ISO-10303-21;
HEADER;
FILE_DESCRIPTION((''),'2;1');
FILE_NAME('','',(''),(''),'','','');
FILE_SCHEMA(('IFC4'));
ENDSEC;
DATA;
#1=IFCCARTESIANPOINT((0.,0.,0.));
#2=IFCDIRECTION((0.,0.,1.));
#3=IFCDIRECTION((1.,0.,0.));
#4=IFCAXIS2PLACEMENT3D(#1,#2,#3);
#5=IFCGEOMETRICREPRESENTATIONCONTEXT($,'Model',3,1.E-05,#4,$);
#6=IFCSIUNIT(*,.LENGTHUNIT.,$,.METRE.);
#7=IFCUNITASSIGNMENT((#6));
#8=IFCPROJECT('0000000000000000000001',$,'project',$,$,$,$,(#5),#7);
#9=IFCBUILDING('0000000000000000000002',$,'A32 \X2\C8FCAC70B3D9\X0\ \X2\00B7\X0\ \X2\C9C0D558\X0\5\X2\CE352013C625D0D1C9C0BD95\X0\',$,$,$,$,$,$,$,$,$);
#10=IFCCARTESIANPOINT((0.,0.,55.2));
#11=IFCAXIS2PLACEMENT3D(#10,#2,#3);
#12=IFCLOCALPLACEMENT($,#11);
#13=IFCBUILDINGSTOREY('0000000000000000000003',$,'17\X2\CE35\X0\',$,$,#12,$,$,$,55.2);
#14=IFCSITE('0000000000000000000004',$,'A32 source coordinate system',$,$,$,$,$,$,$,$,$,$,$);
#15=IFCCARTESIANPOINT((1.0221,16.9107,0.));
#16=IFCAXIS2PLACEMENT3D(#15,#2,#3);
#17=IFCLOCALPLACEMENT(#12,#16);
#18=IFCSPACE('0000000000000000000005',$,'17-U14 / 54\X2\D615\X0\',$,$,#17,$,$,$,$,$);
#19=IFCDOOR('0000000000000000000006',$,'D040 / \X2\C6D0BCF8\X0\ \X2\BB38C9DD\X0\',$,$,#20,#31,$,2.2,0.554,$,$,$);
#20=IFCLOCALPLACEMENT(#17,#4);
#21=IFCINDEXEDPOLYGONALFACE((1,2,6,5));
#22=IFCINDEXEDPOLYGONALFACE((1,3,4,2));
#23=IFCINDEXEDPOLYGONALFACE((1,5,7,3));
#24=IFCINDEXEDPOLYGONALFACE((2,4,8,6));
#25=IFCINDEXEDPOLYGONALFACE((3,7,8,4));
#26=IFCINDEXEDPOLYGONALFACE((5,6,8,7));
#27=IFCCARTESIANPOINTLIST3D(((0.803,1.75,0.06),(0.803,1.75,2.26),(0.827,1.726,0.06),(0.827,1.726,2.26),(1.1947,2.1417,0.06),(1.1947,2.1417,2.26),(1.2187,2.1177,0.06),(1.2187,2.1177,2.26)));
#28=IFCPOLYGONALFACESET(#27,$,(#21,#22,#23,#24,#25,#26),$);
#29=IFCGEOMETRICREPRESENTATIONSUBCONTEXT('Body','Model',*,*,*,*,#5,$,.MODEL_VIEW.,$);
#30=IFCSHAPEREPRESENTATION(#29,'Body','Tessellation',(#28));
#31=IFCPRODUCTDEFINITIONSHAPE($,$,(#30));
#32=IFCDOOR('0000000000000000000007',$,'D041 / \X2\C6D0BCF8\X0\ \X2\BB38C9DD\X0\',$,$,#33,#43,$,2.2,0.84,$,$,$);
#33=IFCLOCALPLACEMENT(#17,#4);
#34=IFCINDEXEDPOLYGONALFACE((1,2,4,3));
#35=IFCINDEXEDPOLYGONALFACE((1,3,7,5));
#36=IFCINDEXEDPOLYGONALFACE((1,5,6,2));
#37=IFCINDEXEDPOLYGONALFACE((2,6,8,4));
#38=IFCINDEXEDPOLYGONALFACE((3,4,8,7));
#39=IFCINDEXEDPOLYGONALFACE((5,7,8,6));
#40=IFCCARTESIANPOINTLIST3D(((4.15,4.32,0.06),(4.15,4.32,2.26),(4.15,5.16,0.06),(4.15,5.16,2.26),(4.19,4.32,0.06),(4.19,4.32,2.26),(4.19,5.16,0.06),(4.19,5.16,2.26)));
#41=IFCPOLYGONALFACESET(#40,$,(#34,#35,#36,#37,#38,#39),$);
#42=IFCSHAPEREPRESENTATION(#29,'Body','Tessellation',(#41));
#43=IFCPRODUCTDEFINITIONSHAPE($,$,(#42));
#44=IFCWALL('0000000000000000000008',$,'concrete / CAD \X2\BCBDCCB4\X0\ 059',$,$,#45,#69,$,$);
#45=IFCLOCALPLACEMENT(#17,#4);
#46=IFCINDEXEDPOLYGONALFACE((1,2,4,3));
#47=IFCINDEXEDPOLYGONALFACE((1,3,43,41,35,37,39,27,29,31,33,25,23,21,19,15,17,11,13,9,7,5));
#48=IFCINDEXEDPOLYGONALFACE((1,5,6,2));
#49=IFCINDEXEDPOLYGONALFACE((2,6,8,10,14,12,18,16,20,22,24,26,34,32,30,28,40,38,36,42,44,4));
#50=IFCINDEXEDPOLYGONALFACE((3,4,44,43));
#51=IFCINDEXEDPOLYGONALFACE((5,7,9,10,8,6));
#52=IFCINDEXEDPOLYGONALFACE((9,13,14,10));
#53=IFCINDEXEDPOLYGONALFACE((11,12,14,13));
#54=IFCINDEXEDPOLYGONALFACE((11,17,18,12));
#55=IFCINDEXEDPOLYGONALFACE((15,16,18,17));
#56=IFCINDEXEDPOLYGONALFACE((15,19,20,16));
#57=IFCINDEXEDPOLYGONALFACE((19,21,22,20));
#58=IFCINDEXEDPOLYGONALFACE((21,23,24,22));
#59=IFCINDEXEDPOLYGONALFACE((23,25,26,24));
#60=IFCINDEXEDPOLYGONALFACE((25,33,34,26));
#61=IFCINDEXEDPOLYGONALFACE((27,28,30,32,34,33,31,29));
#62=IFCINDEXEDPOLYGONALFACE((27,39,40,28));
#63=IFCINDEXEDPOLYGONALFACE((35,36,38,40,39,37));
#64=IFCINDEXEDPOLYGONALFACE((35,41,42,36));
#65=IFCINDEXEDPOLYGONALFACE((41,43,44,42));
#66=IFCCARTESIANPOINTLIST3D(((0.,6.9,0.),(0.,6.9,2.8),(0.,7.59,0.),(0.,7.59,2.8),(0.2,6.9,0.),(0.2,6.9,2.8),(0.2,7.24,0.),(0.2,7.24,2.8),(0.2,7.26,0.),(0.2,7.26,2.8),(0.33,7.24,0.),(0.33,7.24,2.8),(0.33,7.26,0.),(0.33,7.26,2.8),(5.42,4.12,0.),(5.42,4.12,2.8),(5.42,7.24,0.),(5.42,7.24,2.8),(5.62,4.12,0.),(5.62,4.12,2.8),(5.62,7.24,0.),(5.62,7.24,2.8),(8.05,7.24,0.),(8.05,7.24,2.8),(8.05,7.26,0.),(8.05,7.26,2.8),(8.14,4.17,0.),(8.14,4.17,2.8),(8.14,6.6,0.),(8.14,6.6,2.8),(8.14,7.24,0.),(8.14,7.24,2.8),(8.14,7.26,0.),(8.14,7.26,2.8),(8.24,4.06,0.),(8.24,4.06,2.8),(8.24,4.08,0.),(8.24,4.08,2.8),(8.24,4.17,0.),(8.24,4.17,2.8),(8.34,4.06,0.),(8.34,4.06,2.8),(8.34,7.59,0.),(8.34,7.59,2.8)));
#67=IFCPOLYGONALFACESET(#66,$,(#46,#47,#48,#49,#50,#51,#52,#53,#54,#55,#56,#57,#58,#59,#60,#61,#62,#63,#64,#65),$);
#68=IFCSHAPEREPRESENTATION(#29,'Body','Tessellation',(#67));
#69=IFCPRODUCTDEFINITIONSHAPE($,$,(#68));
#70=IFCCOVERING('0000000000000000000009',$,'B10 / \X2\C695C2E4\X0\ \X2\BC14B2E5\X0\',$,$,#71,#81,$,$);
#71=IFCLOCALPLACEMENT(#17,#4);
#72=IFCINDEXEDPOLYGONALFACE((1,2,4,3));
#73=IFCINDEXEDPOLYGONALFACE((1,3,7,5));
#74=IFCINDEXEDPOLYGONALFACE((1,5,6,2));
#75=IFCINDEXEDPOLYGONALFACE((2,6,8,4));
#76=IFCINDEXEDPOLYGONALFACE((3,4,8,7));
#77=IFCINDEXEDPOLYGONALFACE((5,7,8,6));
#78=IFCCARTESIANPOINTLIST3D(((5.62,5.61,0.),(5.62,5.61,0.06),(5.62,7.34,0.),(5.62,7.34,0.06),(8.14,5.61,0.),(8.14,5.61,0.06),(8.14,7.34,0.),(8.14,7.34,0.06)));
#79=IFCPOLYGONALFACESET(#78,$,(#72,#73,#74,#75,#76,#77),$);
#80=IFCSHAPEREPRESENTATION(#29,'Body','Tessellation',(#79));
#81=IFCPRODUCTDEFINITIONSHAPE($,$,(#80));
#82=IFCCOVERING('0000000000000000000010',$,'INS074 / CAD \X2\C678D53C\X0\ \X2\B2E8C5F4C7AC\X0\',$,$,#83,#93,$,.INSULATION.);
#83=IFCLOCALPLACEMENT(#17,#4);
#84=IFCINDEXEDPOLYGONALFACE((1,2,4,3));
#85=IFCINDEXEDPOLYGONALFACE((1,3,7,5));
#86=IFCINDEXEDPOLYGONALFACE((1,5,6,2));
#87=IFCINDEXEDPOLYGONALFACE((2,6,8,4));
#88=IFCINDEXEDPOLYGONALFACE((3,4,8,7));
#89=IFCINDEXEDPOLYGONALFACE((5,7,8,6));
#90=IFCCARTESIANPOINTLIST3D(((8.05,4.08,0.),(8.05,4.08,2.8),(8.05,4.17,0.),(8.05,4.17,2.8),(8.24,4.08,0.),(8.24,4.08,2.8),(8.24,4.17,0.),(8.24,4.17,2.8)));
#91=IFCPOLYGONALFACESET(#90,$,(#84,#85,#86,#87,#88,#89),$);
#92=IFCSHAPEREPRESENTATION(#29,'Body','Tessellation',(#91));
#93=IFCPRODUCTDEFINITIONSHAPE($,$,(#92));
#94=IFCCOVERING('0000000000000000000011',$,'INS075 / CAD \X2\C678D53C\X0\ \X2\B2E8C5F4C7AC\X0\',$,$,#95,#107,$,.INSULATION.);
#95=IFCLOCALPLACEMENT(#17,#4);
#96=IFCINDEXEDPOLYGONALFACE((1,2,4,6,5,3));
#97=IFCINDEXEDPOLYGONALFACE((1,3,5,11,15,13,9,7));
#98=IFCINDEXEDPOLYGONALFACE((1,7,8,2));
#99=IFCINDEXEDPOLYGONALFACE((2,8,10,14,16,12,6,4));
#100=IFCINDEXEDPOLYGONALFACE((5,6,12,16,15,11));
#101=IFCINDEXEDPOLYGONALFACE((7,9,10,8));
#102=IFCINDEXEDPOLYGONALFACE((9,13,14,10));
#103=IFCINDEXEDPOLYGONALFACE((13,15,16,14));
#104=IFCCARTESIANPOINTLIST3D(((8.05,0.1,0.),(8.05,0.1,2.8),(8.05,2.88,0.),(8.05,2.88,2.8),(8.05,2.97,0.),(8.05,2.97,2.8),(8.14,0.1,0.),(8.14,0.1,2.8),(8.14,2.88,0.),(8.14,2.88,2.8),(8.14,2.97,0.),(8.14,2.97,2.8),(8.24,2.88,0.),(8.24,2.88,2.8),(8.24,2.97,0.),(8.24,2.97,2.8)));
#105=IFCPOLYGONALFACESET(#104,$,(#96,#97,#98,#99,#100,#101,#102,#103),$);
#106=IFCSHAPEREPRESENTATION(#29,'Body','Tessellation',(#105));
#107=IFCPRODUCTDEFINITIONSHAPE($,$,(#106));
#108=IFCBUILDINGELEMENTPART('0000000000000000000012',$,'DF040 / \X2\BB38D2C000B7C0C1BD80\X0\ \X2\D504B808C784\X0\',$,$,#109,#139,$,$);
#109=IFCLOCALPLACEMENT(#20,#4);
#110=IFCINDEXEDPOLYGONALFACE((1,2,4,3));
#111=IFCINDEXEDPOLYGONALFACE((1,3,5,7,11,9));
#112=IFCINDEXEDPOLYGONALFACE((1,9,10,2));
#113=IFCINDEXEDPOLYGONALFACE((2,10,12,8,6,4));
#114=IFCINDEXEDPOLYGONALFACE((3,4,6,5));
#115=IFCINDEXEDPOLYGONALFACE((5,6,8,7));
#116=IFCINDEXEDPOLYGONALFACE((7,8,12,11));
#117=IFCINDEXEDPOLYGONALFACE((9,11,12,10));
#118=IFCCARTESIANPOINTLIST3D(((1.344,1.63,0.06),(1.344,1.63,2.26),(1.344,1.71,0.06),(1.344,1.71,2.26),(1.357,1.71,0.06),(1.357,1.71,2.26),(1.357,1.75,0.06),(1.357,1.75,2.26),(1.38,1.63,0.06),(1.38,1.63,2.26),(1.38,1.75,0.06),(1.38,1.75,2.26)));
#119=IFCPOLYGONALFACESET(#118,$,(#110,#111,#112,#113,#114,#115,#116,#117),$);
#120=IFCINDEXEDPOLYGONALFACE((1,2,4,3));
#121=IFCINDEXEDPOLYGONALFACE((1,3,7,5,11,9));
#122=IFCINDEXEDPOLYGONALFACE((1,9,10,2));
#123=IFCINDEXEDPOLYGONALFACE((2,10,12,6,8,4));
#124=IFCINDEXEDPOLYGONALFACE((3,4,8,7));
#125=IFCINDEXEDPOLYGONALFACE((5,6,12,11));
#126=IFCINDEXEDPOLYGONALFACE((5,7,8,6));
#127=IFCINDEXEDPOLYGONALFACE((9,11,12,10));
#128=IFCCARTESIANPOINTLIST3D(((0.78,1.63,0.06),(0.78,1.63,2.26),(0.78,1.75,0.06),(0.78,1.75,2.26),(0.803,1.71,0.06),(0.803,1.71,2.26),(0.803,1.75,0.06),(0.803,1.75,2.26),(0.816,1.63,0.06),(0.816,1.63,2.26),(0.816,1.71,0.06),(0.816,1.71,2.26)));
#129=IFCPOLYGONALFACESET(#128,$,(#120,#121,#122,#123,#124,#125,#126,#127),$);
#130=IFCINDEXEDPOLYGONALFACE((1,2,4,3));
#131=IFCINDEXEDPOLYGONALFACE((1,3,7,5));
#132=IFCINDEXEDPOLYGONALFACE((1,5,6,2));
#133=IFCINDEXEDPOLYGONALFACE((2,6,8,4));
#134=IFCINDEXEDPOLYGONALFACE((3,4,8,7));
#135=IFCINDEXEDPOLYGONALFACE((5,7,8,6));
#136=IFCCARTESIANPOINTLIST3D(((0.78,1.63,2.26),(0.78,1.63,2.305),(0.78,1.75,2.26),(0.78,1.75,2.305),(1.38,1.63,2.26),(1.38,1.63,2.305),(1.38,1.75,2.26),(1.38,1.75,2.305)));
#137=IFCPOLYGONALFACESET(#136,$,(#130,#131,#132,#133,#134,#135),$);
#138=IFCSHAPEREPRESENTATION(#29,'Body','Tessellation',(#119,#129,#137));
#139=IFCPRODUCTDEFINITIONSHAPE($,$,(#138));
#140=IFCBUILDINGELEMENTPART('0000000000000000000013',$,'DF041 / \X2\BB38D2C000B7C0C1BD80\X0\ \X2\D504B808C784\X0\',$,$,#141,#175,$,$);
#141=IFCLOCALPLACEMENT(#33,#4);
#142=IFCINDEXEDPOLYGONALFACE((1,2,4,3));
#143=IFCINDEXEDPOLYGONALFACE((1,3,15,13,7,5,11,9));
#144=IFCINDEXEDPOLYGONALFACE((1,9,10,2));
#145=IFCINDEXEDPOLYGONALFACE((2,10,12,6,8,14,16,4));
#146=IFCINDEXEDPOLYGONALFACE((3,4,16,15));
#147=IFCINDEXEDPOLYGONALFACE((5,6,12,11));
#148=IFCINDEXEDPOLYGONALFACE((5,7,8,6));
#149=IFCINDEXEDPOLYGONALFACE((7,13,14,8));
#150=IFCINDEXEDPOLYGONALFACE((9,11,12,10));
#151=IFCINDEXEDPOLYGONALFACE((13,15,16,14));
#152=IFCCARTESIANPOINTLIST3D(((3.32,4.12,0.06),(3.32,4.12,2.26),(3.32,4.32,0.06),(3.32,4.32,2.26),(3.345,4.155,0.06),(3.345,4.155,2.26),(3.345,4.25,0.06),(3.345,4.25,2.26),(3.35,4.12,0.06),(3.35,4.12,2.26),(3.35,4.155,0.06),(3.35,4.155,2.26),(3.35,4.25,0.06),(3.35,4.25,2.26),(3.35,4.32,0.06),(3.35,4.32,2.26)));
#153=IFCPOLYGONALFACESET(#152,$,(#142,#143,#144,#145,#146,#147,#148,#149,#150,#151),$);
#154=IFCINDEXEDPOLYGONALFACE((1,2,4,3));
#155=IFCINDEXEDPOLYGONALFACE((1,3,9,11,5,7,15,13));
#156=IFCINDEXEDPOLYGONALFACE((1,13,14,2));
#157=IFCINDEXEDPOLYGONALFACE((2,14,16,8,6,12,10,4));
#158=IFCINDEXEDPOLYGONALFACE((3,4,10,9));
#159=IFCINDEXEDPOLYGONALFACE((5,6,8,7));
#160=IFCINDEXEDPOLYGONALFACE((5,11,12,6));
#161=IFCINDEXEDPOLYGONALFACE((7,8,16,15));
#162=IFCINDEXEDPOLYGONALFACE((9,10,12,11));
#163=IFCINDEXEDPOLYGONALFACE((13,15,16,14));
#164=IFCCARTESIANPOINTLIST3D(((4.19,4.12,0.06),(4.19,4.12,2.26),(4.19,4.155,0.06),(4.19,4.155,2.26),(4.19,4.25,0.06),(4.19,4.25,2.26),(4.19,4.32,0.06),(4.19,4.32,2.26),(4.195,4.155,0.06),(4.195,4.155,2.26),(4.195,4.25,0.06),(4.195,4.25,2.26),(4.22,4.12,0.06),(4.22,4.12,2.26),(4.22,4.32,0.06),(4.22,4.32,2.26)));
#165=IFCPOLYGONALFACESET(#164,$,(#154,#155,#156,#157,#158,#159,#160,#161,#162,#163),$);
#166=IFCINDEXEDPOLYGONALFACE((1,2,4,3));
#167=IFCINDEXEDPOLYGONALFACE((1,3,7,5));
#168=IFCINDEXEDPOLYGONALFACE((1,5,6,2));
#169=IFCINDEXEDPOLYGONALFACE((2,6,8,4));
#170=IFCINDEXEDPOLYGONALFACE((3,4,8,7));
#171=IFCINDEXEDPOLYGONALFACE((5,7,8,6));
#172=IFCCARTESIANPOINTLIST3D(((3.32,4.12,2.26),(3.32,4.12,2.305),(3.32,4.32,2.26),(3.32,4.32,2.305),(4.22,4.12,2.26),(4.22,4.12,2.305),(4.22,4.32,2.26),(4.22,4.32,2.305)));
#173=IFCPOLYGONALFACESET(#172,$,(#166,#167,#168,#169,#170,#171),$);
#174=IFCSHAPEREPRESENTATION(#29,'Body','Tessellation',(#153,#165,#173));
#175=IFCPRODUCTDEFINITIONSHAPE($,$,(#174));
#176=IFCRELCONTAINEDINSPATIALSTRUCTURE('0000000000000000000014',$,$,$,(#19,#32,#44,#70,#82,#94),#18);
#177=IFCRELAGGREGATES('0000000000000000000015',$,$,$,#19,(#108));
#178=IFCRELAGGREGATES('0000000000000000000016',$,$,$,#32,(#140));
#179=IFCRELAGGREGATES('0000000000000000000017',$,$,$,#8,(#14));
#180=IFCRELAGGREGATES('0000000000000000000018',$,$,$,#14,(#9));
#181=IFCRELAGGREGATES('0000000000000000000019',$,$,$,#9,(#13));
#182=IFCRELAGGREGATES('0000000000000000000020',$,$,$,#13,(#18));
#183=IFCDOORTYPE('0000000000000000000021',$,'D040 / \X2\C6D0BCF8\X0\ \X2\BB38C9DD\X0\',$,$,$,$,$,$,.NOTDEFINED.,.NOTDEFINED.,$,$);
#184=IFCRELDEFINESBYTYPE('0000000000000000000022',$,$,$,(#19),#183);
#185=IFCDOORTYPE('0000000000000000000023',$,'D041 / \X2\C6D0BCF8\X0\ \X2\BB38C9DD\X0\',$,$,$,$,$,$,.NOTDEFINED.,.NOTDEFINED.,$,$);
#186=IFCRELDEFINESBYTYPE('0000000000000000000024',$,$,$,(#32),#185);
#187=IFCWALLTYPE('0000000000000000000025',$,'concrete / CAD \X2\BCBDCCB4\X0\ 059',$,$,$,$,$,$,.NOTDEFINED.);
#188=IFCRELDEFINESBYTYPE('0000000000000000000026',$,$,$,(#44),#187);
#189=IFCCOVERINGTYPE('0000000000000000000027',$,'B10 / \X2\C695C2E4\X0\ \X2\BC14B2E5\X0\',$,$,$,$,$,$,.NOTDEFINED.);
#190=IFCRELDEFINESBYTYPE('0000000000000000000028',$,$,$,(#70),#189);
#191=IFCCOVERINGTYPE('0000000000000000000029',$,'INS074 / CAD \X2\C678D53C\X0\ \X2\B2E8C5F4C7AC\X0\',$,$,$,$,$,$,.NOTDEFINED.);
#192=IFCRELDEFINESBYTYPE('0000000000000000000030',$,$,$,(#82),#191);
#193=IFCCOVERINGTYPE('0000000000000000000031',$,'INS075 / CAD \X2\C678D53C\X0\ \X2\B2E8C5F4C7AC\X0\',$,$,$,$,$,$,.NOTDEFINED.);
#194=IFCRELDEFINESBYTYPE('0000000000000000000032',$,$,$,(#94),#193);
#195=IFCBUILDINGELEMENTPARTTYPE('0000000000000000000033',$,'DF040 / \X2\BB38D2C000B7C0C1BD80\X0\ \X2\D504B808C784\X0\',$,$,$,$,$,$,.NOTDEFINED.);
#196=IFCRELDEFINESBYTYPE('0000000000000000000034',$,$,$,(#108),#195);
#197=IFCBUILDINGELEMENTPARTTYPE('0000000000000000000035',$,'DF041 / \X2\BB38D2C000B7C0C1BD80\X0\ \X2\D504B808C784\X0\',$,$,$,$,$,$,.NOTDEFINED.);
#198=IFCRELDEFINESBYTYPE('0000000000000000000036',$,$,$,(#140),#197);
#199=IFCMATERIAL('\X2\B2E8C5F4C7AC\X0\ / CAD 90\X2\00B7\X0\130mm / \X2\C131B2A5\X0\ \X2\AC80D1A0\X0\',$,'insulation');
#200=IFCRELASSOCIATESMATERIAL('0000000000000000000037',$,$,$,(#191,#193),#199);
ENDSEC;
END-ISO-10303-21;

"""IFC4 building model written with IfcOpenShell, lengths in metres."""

from ifc_helpers import new_model, si_unit, frame, origin, origin_with_axes, place, context, subcontext, project, spatial, polyline, outline, extrude, source, transform, mapped, material, type_object, type_shapes, element, aggregate, save


model = new_model("IFC4")

# Units and contexts
model_context = context("Model", 3, precision=1e-05, world=origin_with_axes())
body_context = subcontext(model_context, "Body", "Model", "MODEL_VIEW")
ifc_project = project(units=[si_unit("LENGTHUNIT", "METRE")], contexts=[model_context])

# Site, building, storey, space
storey_placement = place(None, frame((0.0, 0.0, 55.2), z_axis=(0.0, 0.0, 1.0), x_axis=(1.0, 0.0, 0.0)))
space_1_placement = place(storey_placement, frame((1.0221, 16.9107, 0.0), z_axis=(0.0, 0.0, 1.0), x_axis=(1.0, 0.0, 0.0)))
site = spatial("IfcSite", under=ifc_project, Name="A32 source coordinate system")
building = spatial("IfcBuilding", under=site, Name="A32 주거동 · 지하5층–옥탑지붕")
storey = spatial("IfcBuildingStorey", under=building, at=storey_placement, Name="17층", Elevation=55.2)
space_1 = spatial("IfcSpace", under=storey, at=space_1_placement, Name="17-U14 / 54형")

# Doors
door_type_1 = type_object("IfcDoorType", Name="D040 / 원본 문짝", OperationType="NOTDEFINED", PredefinedType="NOTDEFINED")
shared_shape_1 = source(origin(), body_context, "Body", "SweptSolid", [
    extrude(outline(polyline([(0.803, 1.75), (1.1947, 2.1417), (1.2187, 2.1177), (0.827, 1.726), (0.803, 1.75)])), frame((0.0, 0.0, 0.06)), (0.0, 0.0, 1.0), 2.2),
])
type_shapes(door_type_1, [shared_shape_1])
door_1_placement = place(space_1_placement, origin_with_axes())
door_1 = element("IfcDoor", 1, at=door_1_placement, inside=space_1, type_object=door_type_1, Name="D040 / 원본 문짝", OverallHeight=2.2, OverallWidth=0.554, context=body_context, shape_type="MappedRepresentation", body=[
    mapped(shared_shape_1, transform((0.0, 0.0, 0.0), scale=1.0)),
])
door_type_2 = type_object("IfcDoorType", Name="D041 / 원본 문짝", OperationType="NOTDEFINED", PredefinedType="NOTDEFINED")
shared_shape_2 = source(origin(), body_context, "Body", "SweptSolid", [
    extrude(outline(polyline([(4.15, 5.16), (4.19, 5.16), (4.19, 4.32), (4.15, 4.32), (4.15, 5.16)])), frame((0.0, 0.0, 0.06)), (0.0, 0.0, 1.0), 2.2),
])
type_shapes(door_type_2, [shared_shape_2])
door_2_placement = place(space_1_placement, origin_with_axes())
door_2 = element("IfcDoor", 2, at=door_2_placement, inside=space_1, type_object=door_type_2, Name="D041 / 원본 문짝", OverallHeight=2.2, OverallWidth=0.84, context=body_context, shape_type="MappedRepresentation", body=[
    mapped(shared_shape_2, transform((0.0, 0.0, 0.0), scale=1.0)),
])

# Wall
wall_type_1 = type_object("IfcWallType", Name="concrete / CAD 벽체 059", PredefinedType="NOTDEFINED")
shared_shape_3 = source(origin(), body_context, "Body", "SweptSolid", [
    extrude(outline(polyline([(8.05, 7.26), (8.05, 7.24), (5.62, 7.24), (5.62, 4.12), (5.42, 4.12), (5.42, 7.24), (0.33, 7.24), (0.33, 7.26), (0.2, 7.26), (0.2, 7.24), (0.2, 6.9), (0.0, 6.9), (0.0, 7.59), (8.34, 7.59), (8.34, 4.06), (8.24, 4.06), (8.24, 4.08), (8.24, 4.17), (8.14, 4.17), (8.14, 6.6), (8.14, 7.24), (8.14, 7.26), (8.05, 7.26)])), origin(), (0.0, 0.0, 1.0), 2.8),
])
type_shapes(wall_type_1, [shared_shape_3])
wall_1_placement = place(space_1_placement, origin_with_axes())
element("IfcWall", 3, at=wall_1_placement, inside=space_1, type_object=wall_type_1, Name="concrete / CAD 벽체 059", context=body_context, shape_type="MappedRepresentation", body=[
    mapped(shared_shape_3, transform((0.0, 0.0, 0.0), scale=1.0)),
])

# Coverings
covering_type_1 = type_object("IfcCoveringType", Name="B10 / 욕실 바닥", PredefinedType="NOTDEFINED")
shared_shape_4 = source(origin(), body_context, "Body", "SweptSolid", [
    extrude(outline(polyline([(8.14, 5.61), (5.62, 5.61), (5.62, 7.34), (8.14, 7.34), (8.14, 5.61)])), origin(), (0.0, 0.0, 1.0), 0.06),
])
type_shapes(covering_type_1, [shared_shape_4])
covering_1_placement = place(space_1_placement, origin_with_axes())
element("IfcCovering", 4, at=covering_1_placement, inside=space_1, type_object=covering_type_1, Name="B10 / 욕실 바닥", context=body_context, shape_type="MappedRepresentation", body=[
    mapped(shared_shape_4, transform((0.0, 0.0, 0.0), scale=1.0)),
])
ifc_material = material(Name="단열재 / CAD 90·130mm / 성능 검토", Category="insulation")
covering_type_2 = type_object("IfcCoveringType", Name="INS074 / CAD 외피 단열재", PredefinedType="NOTDEFINED", material=ifc_material)
shared_shape_5 = source(origin(), body_context, "Body", "SweptSolid", [
    extrude(outline(polyline([(8.05, 4.08), (8.05, 4.17), (8.24, 4.17), (8.24, 4.08), (8.05, 4.08)])), origin(), (0.0, 0.0, 1.0), 2.8),
])
type_shapes(covering_type_2, [shared_shape_5])
covering_2_placement = place(space_1_placement, origin_with_axes())
element("IfcCovering", 5, at=covering_2_placement, inside=space_1, type_object=covering_type_2, Name="INS074 / CAD 외피 단열재", PredefinedType="INSULATION", context=body_context, shape_type="MappedRepresentation", body=[
    mapped(shared_shape_5, transform((0.0, 0.0, 0.0), scale=1.0)),
])
covering_type_3 = type_object("IfcCoveringType", Name="INS075 / CAD 외피 단열재", PredefinedType="NOTDEFINED", material=ifc_material)
shared_shape_6 = source(origin(), body_context, "Body", "SweptSolid", [
    extrude(outline(polyline([(8.24, 2.88), (8.14, 2.88), (8.14, 0.1), (8.05, 0.1), (8.05, 2.88), (8.05, 2.97), (8.14, 2.97), (8.24, 2.97), (8.24, 2.88)])), origin(), (0.0, 0.0, 1.0), 2.8),
])
type_shapes(covering_type_3, [shared_shape_6])
covering_3_placement = place(space_1_placement, origin_with_axes())
element("IfcCovering", 6, at=covering_3_placement, inside=space_1, type_object=covering_type_3, Name="INS075 / CAD 외피 단열재", PredefinedType="INSULATION", context=body_context, shape_type="MappedRepresentation", body=[
    mapped(shared_shape_6, transform((0.0, 0.0, 0.0), scale=1.0)),
])

# Building element parts
building_element_part_type_1 = type_object("IfcBuildingElementPartType", Name="DF040 / 문틀·상부 프레임", PredefinedType="NOTDEFINED")
shared_shape_7 = source(origin(), body_context, "Body", "SweptSolid", [
    extrude(outline(polyline([(1.344, 1.63), (1.344, 1.71), (1.357, 1.71), (1.357, 1.75), (1.38, 1.75), (1.38, 1.63), (1.344, 1.63)])), frame((0.0, 0.0, 0.06)), (0.0, 0.0, 1.0), 2.2),
    extrude(outline(polyline([(0.78, 1.75), (0.803, 1.75), (0.803, 1.71), (0.816, 1.71), (0.816, 1.63), (0.78, 1.63), (0.78, 1.75)])), frame((0.0, 0.0, 0.06)), (0.0, 0.0, 1.0), 2.2),
    extrude(outline(polyline([(0.78, 1.63), (0.78, 1.75), (1.38, 1.75), (1.38, 1.63), (0.78, 1.63)])), frame((0.0, 0.0, 2.26)), (0.0, 0.0, 1.0), 0.045),
])
type_shapes(building_element_part_type_1, [shared_shape_7])
building_element_part_1_placement = place(door_1_placement, origin_with_axes())
building_element_part_1 = element("IfcBuildingElementPart", 7, at=building_element_part_1_placement, type_object=building_element_part_type_1, Name="DF040 / 문틀·상부 프레임", context=body_context, shape_type="MappedRepresentation", body=[
    mapped(shared_shape_7, transform((0.0, 0.0, 0.0), scale=1.0)),
])
aggregate(door_1, [building_element_part_1])
building_element_part_type_2 = type_object("IfcBuildingElementPartType", Name="DF041 / 문틀·상부 프레임", PredefinedType="NOTDEFINED")
shared_shape_8 = source(origin(), body_context, "Body", "SweptSolid", [
    extrude(outline(polyline([(3.35, 4.32), (3.35, 4.25), (3.345, 4.25), (3.345, 4.155), (3.35, 4.155), (3.35, 4.12), (3.32, 4.12), (3.32, 4.32), (3.35, 4.32)])), frame((0.0, 0.0, 0.06)), (0.0, 0.0, 1.0), 2.2),
    extrude(outline(polyline([(4.22, 4.12), (4.19, 4.12), (4.19, 4.155), (4.195, 4.155), (4.195, 4.25), (4.19, 4.25), (4.19, 4.32), (4.22, 4.32), (4.22, 4.12)])), frame((0.0, 0.0, 0.06)), (0.0, 0.0, 1.0), 2.2),
    extrude(outline(polyline([(3.32, 4.12), (3.32, 4.32), (4.22, 4.32), (4.22, 4.12), (3.32, 4.12)])), frame((0.0, 0.0, 2.26)), (0.0, 0.0, 1.0), 0.045),
])
type_shapes(building_element_part_type_2, [shared_shape_8])
building_element_part_2_placement = place(door_2_placement, origin_with_axes())
building_element_part_2 = element("IfcBuildingElementPart", 8, at=building_element_part_2_placement, type_object=building_element_part_type_2, Name="DF041 / 문틀·상부 프레임", context=body_context, shape_type="MappedRepresentation", body=[
    mapped(shared_shape_8, transform((0.0, 0.0, 0.0), scale=1.0)),
])
aggregate(door_2, [building_element_part_2])

save(model, "model.ifc")
